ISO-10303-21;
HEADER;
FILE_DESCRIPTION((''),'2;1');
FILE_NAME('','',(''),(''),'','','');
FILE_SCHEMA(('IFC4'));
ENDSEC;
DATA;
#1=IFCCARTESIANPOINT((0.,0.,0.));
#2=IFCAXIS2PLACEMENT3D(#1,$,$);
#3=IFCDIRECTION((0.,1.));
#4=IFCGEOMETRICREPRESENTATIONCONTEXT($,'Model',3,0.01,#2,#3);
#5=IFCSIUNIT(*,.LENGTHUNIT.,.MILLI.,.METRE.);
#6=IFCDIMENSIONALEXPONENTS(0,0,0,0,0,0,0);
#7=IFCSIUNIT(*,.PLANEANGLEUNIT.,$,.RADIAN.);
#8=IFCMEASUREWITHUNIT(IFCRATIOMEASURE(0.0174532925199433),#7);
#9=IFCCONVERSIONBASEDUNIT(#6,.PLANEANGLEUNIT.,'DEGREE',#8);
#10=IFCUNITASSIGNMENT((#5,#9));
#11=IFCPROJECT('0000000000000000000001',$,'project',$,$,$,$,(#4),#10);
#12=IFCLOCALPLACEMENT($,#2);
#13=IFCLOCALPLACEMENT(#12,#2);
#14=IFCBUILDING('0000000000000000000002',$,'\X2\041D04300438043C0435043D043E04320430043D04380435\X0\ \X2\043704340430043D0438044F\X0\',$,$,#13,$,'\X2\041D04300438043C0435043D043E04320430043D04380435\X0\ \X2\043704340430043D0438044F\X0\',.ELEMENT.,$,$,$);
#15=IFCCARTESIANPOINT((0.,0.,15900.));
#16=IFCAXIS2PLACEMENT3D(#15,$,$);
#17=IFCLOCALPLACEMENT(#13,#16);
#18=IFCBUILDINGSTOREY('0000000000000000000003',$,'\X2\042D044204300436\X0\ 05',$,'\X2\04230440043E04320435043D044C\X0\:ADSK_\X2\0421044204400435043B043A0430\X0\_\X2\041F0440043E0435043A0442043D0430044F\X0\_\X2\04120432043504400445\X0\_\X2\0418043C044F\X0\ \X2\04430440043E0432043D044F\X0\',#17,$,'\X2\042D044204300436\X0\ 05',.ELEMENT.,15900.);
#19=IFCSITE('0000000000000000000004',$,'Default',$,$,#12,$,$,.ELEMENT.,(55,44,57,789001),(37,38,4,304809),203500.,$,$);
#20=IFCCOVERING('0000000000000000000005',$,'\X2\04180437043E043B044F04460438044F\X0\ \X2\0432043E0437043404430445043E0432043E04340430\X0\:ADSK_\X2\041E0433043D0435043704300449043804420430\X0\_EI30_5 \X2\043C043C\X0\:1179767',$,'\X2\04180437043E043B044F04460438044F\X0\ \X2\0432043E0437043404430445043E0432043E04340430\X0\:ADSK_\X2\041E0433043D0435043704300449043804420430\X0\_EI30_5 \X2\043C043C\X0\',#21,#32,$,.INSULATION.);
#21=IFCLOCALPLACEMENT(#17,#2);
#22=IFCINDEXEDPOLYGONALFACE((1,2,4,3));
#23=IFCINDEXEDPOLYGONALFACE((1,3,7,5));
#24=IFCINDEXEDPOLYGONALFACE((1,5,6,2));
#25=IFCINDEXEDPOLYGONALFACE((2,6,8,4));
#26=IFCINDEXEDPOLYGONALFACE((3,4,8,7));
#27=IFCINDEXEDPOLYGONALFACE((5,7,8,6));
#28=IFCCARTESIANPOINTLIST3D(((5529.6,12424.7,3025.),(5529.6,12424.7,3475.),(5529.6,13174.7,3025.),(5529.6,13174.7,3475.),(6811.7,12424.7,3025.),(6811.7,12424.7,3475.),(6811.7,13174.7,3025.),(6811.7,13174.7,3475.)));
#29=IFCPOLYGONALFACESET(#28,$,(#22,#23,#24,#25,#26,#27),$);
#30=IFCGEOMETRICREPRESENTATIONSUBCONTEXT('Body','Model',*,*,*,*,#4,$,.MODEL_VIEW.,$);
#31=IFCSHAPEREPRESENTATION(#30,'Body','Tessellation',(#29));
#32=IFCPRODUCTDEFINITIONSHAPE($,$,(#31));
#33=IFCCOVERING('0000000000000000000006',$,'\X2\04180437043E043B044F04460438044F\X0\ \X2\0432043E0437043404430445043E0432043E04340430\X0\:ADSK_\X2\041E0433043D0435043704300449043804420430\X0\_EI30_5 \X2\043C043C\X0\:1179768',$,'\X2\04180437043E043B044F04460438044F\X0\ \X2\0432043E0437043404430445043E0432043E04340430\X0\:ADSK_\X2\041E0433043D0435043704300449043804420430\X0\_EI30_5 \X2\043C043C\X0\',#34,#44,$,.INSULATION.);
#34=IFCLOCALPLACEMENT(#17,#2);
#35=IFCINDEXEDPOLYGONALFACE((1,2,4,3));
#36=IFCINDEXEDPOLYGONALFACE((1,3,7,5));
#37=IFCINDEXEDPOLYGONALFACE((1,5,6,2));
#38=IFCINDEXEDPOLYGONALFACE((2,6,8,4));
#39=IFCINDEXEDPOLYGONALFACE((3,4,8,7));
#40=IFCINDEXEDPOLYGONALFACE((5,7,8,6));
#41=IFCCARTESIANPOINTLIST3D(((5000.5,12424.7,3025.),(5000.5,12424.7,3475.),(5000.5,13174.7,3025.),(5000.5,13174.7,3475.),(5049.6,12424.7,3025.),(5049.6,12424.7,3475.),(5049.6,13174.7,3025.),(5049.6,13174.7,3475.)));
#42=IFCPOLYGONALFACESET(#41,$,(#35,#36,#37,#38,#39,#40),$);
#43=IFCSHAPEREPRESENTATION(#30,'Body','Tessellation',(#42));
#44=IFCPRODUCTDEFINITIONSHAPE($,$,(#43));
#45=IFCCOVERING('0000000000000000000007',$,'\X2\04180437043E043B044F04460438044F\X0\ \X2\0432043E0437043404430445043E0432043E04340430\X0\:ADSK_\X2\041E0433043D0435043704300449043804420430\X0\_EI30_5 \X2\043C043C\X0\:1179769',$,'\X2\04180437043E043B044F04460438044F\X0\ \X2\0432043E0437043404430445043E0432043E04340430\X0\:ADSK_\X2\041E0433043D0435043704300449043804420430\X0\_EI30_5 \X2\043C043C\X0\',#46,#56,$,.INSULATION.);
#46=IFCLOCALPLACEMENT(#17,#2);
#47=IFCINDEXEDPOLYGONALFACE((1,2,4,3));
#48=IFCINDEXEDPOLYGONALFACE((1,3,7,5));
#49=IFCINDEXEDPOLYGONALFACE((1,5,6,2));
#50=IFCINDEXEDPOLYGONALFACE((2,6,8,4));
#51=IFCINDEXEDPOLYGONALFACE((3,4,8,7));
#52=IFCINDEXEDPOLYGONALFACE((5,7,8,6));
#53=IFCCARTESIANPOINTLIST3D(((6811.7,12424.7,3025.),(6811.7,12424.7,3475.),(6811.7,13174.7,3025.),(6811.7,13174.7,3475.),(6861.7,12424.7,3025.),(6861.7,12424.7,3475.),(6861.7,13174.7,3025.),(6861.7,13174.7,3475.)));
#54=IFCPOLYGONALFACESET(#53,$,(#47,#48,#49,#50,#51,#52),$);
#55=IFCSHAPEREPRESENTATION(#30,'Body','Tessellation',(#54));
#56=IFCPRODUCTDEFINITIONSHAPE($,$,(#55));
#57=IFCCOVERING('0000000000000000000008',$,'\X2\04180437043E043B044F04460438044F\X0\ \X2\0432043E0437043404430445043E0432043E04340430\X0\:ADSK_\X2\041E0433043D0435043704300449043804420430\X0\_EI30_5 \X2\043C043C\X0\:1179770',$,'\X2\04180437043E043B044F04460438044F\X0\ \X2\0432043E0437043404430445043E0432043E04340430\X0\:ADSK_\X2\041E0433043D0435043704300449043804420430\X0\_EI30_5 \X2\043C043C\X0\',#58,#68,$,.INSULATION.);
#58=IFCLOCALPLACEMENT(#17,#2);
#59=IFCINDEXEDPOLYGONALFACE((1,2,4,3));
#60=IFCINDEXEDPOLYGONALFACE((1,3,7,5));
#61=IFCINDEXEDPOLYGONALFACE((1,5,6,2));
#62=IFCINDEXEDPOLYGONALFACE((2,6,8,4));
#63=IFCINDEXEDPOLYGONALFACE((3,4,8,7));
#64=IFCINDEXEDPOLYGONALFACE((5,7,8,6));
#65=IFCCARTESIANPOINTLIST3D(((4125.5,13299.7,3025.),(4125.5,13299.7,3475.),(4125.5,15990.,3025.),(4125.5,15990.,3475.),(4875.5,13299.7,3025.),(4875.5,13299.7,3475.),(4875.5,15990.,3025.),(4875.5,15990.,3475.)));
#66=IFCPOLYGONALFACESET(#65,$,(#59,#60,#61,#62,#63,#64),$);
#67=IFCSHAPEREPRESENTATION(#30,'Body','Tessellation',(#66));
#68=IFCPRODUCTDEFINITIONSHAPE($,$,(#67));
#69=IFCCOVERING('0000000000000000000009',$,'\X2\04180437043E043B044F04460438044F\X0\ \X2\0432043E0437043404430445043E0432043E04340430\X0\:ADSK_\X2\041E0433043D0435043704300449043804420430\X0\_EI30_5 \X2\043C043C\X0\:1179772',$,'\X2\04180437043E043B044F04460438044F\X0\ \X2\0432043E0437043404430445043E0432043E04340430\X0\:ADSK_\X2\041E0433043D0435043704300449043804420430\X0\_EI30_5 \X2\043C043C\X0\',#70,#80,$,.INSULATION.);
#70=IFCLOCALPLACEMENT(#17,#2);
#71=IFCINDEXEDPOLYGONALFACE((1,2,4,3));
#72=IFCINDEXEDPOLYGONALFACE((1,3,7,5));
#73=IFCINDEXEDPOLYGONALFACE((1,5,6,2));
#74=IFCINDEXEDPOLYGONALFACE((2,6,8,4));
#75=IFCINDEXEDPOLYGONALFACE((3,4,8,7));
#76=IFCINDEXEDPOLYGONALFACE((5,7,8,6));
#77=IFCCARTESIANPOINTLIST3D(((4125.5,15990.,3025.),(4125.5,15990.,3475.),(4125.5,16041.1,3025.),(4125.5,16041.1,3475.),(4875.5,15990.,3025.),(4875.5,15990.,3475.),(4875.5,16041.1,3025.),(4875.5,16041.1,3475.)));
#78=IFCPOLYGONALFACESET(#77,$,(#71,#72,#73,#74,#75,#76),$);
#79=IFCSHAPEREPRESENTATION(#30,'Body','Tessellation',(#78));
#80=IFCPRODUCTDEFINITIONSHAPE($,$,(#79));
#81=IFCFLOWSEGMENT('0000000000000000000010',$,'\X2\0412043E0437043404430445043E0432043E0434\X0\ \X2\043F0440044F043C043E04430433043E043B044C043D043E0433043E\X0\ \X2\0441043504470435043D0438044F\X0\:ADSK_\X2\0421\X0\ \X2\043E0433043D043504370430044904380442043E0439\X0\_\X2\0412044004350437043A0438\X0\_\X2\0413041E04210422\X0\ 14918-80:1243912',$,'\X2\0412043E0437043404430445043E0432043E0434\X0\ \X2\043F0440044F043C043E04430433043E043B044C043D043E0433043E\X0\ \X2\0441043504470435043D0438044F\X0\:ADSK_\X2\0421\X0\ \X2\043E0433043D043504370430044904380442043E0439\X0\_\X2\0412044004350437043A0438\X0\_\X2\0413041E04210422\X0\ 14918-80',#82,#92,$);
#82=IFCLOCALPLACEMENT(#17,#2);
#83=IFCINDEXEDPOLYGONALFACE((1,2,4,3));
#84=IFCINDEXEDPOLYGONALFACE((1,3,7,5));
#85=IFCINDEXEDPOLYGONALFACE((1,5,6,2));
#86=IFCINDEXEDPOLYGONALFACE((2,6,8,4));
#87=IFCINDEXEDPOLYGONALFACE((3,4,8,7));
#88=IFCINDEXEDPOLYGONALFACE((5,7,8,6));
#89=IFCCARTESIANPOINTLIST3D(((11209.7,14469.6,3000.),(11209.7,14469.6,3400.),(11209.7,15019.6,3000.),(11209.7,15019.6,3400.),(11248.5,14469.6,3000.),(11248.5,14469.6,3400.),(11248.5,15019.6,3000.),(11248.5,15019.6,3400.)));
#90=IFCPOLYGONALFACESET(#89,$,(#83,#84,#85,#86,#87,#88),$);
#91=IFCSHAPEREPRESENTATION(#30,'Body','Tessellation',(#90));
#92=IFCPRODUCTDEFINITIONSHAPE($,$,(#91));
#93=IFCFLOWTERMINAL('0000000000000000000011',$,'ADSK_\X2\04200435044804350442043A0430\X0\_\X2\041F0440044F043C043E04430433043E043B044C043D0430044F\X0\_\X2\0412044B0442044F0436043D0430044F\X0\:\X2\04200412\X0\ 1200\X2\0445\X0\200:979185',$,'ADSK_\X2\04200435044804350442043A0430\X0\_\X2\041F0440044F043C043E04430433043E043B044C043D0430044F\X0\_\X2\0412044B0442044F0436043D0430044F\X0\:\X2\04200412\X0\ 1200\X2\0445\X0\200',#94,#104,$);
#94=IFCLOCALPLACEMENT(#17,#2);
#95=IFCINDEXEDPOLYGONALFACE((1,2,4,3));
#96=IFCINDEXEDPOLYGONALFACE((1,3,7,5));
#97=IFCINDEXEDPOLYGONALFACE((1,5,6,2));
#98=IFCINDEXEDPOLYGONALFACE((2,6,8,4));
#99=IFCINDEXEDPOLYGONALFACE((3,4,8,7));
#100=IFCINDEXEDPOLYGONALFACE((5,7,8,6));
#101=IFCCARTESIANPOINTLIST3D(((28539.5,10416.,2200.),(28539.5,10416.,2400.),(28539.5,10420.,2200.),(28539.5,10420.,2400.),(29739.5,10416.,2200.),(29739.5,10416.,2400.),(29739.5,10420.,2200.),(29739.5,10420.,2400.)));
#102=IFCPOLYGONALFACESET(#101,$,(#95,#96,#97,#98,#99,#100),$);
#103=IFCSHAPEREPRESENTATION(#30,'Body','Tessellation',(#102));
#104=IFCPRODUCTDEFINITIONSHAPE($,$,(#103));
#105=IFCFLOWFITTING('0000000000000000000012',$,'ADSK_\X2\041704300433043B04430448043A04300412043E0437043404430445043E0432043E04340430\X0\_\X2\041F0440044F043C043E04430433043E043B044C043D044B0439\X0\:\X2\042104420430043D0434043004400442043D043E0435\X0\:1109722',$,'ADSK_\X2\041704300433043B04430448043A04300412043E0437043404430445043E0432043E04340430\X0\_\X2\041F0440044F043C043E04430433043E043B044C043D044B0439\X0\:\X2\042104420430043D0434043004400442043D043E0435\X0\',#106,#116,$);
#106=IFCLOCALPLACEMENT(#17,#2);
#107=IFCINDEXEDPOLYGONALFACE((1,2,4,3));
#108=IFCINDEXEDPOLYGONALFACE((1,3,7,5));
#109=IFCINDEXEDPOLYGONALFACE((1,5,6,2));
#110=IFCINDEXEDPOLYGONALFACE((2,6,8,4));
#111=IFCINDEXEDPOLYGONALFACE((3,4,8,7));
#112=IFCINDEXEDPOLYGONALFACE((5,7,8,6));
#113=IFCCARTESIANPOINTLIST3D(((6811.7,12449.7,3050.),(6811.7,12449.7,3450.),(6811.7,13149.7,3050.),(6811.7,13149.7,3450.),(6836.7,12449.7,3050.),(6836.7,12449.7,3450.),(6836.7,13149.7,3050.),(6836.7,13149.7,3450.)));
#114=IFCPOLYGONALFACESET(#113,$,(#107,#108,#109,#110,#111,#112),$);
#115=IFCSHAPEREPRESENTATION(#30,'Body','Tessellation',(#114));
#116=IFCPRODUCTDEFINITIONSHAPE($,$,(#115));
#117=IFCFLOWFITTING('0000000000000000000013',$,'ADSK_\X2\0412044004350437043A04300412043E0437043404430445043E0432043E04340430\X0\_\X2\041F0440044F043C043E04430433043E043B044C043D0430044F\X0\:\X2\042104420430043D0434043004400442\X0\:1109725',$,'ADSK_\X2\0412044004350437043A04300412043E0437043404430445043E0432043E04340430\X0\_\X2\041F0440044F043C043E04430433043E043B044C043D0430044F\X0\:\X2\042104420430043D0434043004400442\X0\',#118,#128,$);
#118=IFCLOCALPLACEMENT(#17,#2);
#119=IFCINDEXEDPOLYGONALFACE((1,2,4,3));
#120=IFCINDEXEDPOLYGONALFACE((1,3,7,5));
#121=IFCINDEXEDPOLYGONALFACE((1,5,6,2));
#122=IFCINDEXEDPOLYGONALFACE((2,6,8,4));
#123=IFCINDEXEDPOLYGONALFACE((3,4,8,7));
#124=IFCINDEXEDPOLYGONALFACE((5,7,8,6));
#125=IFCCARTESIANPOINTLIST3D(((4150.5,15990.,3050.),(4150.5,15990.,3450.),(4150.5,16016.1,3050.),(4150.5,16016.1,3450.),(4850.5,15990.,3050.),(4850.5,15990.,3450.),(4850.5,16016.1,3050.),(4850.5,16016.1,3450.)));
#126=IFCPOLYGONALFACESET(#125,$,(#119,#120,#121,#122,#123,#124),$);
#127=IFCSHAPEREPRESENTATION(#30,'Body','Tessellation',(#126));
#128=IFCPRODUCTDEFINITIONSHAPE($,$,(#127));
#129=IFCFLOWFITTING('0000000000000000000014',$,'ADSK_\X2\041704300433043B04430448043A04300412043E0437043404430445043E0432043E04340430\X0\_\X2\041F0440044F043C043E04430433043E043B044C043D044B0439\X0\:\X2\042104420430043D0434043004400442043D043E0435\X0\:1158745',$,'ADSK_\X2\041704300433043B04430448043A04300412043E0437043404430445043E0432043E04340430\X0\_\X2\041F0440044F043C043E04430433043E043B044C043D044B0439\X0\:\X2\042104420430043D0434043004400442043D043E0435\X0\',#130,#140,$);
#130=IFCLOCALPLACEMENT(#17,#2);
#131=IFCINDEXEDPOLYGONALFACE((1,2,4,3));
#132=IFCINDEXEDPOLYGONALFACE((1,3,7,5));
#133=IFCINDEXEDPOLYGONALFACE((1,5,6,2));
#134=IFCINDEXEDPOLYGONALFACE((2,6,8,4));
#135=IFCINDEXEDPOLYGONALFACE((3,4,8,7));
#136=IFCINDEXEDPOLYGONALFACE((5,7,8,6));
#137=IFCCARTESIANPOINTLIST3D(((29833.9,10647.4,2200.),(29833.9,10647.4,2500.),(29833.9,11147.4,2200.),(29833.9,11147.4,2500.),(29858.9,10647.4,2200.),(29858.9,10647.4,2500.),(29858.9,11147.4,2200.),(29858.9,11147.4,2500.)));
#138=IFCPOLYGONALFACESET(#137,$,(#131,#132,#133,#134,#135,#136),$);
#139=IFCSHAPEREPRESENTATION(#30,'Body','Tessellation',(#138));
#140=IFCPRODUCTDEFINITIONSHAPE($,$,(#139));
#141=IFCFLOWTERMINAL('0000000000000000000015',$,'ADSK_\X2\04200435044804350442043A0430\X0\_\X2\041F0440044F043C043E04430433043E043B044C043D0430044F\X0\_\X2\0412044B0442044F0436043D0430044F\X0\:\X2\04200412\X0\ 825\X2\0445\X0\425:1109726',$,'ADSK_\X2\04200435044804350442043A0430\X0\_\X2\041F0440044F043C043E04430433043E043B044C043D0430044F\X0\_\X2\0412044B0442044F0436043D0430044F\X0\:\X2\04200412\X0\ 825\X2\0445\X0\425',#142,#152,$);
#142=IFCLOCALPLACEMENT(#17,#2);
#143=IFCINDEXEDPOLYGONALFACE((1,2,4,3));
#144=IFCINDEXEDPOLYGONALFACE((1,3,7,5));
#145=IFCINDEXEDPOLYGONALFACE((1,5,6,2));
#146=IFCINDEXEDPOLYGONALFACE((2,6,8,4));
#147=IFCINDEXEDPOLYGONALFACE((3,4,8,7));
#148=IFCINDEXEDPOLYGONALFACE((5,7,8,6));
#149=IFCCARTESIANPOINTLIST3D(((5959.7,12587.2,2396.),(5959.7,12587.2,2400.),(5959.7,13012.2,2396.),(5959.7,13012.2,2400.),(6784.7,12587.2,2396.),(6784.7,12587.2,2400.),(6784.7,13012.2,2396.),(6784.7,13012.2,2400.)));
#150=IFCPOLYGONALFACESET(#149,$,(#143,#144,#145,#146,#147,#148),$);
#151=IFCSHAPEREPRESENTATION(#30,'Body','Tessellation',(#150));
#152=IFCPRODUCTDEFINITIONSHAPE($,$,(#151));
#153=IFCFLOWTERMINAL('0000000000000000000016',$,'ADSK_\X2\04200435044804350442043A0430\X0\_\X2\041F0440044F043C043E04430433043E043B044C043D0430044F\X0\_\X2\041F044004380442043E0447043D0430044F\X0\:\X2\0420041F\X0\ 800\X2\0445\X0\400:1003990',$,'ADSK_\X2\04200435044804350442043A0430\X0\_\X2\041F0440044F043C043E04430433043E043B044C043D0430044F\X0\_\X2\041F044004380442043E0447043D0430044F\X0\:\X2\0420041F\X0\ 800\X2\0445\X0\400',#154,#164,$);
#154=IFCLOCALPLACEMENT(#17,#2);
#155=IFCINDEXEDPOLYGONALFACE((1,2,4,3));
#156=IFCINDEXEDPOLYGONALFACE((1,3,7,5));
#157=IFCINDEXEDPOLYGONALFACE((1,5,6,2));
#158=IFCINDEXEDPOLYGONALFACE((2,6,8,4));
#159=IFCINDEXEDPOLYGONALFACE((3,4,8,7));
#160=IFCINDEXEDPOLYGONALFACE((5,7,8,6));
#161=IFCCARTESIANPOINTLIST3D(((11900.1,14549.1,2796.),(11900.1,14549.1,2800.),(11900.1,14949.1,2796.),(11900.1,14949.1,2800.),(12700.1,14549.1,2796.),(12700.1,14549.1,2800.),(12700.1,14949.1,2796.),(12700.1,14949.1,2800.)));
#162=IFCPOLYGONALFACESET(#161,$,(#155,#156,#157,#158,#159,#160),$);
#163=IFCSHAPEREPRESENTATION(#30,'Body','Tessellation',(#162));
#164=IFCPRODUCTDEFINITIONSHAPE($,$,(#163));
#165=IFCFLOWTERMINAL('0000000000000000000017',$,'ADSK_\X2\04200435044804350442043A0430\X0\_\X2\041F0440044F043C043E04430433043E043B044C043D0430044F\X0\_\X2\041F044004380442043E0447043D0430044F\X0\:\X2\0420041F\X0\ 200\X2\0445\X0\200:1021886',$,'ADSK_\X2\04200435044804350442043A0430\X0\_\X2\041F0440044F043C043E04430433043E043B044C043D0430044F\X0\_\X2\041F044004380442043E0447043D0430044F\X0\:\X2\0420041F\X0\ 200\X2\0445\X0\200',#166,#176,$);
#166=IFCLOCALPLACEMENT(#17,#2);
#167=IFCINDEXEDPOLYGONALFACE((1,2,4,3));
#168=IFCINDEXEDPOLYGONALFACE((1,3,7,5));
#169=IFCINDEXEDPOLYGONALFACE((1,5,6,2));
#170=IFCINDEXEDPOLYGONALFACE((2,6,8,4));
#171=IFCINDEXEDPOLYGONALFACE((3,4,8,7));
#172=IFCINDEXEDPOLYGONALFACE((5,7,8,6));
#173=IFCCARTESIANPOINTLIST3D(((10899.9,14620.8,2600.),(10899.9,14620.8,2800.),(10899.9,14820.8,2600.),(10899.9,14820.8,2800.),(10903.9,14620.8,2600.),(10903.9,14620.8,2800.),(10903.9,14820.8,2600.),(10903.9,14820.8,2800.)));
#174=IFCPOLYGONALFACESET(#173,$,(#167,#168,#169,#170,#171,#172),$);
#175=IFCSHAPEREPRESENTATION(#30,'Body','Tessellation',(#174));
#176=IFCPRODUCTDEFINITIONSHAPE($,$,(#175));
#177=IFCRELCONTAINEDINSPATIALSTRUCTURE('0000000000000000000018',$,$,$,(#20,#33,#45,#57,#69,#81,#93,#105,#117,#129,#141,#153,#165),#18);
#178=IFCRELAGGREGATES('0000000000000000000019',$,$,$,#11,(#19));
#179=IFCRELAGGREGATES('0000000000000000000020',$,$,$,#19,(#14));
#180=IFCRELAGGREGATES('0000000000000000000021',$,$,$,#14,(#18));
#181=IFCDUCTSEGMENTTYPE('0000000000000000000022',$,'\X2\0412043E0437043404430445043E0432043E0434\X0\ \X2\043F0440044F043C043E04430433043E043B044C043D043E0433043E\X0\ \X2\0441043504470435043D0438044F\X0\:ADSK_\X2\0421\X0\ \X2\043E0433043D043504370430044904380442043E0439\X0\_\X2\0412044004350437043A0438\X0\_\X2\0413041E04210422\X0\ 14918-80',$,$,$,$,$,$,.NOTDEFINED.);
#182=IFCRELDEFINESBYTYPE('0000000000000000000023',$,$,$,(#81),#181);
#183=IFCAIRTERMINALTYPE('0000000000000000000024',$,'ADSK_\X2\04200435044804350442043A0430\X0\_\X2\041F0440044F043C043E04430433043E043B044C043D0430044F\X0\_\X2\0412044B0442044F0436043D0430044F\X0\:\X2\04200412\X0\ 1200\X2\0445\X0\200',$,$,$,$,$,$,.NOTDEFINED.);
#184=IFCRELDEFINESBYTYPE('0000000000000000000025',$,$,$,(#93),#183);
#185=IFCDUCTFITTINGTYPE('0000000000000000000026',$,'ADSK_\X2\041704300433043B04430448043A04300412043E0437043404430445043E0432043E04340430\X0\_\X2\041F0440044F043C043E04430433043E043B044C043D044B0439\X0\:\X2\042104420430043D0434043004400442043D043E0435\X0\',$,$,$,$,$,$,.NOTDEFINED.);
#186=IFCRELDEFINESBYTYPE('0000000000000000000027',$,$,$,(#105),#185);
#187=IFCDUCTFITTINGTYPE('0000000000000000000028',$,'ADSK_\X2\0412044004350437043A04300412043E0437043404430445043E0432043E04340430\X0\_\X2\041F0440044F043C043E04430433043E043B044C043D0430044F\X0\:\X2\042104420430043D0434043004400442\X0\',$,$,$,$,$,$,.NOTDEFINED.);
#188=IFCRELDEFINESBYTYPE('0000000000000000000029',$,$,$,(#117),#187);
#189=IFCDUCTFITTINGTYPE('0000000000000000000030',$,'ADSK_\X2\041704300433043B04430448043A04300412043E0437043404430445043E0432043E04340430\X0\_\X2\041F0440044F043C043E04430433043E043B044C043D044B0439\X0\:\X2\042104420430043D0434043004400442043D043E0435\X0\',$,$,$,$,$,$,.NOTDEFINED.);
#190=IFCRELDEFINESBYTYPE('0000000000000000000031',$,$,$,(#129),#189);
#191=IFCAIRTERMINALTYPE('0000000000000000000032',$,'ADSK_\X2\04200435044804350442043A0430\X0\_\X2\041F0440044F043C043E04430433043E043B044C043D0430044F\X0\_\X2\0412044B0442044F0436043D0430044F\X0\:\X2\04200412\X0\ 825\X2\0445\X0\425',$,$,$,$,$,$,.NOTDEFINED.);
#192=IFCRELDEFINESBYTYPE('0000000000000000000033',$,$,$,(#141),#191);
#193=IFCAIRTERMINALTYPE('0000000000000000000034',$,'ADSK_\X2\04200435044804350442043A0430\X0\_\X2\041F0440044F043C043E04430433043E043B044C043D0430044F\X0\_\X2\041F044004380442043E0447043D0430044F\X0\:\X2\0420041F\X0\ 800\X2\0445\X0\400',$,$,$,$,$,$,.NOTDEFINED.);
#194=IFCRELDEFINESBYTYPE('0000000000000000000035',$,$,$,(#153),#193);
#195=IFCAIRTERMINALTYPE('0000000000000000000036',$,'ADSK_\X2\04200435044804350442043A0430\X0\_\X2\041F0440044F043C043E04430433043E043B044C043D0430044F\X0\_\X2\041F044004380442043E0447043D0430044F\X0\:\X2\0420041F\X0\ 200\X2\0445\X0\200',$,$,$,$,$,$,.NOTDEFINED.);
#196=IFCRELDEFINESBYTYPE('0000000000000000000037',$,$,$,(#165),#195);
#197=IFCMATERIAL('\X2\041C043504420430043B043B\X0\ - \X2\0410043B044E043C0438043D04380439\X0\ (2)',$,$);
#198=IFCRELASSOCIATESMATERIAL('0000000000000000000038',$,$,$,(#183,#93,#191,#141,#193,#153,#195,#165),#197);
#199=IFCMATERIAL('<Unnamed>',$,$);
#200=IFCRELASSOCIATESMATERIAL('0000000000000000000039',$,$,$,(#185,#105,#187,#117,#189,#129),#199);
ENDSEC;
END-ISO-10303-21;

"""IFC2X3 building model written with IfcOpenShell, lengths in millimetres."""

from ifc_helpers import new_model, entity, si_unit, converted_unit, direction, frame, frame_2d, origin, origin_2d_with_axis, place, context, subcontext, project, spatial, rectangle, extrude, source, transform, mapped, material, type_object, type_shapes, element, save


model = new_model("IFC2X3")

# Units and contexts
model_context = context("Model", 3, precision=0.01, world=origin(), true_north=direction((0.0, 1.0)))
body_context = subcontext(model_context, "Body", "Model", "MODEL_VIEW")
ifc_project = project(units=[si_unit("LENGTHUNIT", "METRE", prefix="MILLI"), converted_unit("PLANEANGLEUNIT", "DEGREE", entity("IfcRatioMeasure", 0.0174532925199433), si_unit("PLANEANGLEUNIT", "RADIAN"), dimensions=[0, 0, 0, 0, 0, 0, 0])], contexts=[model_context])

# Site, building, storey
site_placement = place(None, frame((0.0, 0.0, 0.0)))
site = spatial("IfcSite", under=ifc_project, at=site_placement, Name="Default", CompositionType="ELEMENT", RefLatitude=(55, 44, 57, 789001), RefLongitude=(37, 38, 4, 304809), RefElevation=203500.0)
building_placement = place(site_placement, origin())
building = spatial("IfcBuilding", under=site, at=building_placement, Name="Наименование здания", LongName="Наименование здания", CompositionType="ELEMENT")
storey_placement = place(building_placement, frame((0.0, 0.0, 15900.0)))
storey = spatial("IfcBuildingStorey", under=building, at=storey_placement, Name="Этаж 05", ObjectType="Уровень:ADSK_Стрелка_Проектная_Вверх_Имя уровня", LongName="Этаж 05", CompositionType="ELEMENT", Elevation=15900.0)

# Coverings
covering_1_placement = place(storey_placement, frame((5529.6, 12424.7, 3025.0)))
element("IfcCovering", 1, at=covering_1_placement, inside=storey, Name="Изоляция воздуховода:ADSK_Огнезащита_EI30_5 мм:1179767", ObjectType="Изоляция воздуховода:ADSK_Огнезащита_EI30_5 мм", PredefinedType="INSULATION", context=body_context, shape_type="SweptSolid", body=[
    extrude(rectangle(XDim=1282.1, YDim=750.0, at=origin_2d_with_axis()), frame((641.0, 375.0, 0.0)), (0.0, 0.0, 1.0), 450.0),
])
covering_2_placement = place(storey_placement, frame((5000.5, 12424.7, 3025.0)))
element("IfcCovering", 2, at=covering_2_placement, inside=storey, Name="Изоляция воздуховода:ADSK_Огнезащита_EI30_5 мм:1179768", ObjectType="Изоляция воздуховода:ADSK_Огнезащита_EI30_5 мм", PredefinedType="INSULATION", context=body_context, shape_type="SweptSolid", body=[
    extrude(rectangle(XDim=49.2, YDim=750.0, at=frame_2d((0.0, 0.0), x_axis=(1.0, 0.0))), frame((24.6, 375.0, 0.0)), (0.0, 0.0, 1.0), 450.0),
])
covering_3_placement = place(storey_placement, frame((6811.7, 12424.7, 3025.0)))
element("IfcCovering", 3, at=covering_3_placement, inside=storey, Name="Изоляция воздуховода:ADSK_Огнезащита_EI30_5 мм:1179769", ObjectType="Изоляция воздуховода:ADSK_Огнезащита_EI30_5 мм", PredefinedType="INSULATION", context=body_context, shape_type="SweptSolid", body=[
    extrude(rectangle(XDim=50.0, YDim=750.0, at=frame_2d((0.0, 0.0), x_axis=(1.0, 0.0))), frame((25.0, 375.0, 0.0), z_axis=(0.0, 0.0, 1.0), x_axis=(-1.0, 0.0, 0.0)), (0.0, 0.0, 1.0), 450.0),
])
covering_4_placement = place(storey_placement, frame((4125.5, 13299.7, 3025.0)))
element("IfcCovering", 4, at=covering_4_placement, inside=storey, Name="Изоляция воздуховода:ADSK_Огнезащита_EI30_5 мм:1179770", ObjectType="Изоляция воздуховода:ADSK_Огнезащита_EI30_5 мм", PredefinedType="INSULATION", context=body_context, shape_type="SweptSolid", body=[
    extrude(rectangle(XDim=2690.3, YDim=750.0, at=frame_2d((0.0, 0.0), x_axis=(1.0, 0.0))), frame((375.0, 1345.2, 0.0), z_axis=(0.0, 0.0, 1.0), x_axis=(0.0, 1.0, 0.0)), (0.0, 0.0, 1.0), 450.0),
])
covering_5_placement = place(storey_placement, frame((4125.5, 15990.0, 3025.0)))
element("IfcCovering", 5, at=covering_5_placement, inside=storey, Name="Изоляция воздуховода:ADSK_Огнезащита_EI30_5 мм:1179772", ObjectType="Изоляция воздуховода:ADSK_Огнезащита_EI30_5 мм", PredefinedType="INSULATION", context=body_context, shape_type="SweptSolid", body=[
    extrude(rectangle(XDim=750.0, YDim=51.1, at=frame_2d((0.0, 0.0), x_axis=(1.0, 0.0))), frame((375.0, 25.5, 0.0)), (0.0, 0.0, 1.0), 450.0),
])

# Flow segment
duct_segment_type = type_object("IfcDuctSegmentType", Name="Воздуховод прямоугольного сечения:ADSK_С огнезащитой_Врезки_ГОСТ 14918-80", PredefinedType="NOTDEFINED")
flow_segment_placement = place(storey_placement, frame((11209.7, 14469.6, 3000.0)))
element("IfcFlowSegment", 6, at=flow_segment_placement, inside=storey, type_object=duct_segment_type, Name="Воздуховод прямоугольного сечения:ADSK_С огнезащитой_Врезки_ГОСТ 14918-80:1243912", ObjectType="Воздуховод прямоугольного сечения:ADSK_С огнезащитой_Врезки_ГОСТ 14918-80", context=body_context, shape_type="SweptSolid", body=[
    extrude(rectangle(XDim=38.8, YDim=550.0, at=frame_2d((0.0, 0.0), x_axis=(1.0, 0.0))), frame((19.4, 275.0, 0.0)), (0.0, 0.0, 1.0), 400.0),
])

# Flow terminal
ifc_material_1 = material(Name="Металл - Алюминий (2)")
air_terminal_type_1 = type_object("IfcAirTerminalType", Name="ADSK_Решетка_Прямоугольная_Вытяжная:РВ 1200х200", PredefinedType="NOTDEFINED", material=ifc_material_1)
shared_shape_1 = source(origin(), body_context, "Body", "SweptSolid", [
    extrude(rectangle(XDim=4.0, YDim=1200.0, at=origin_2d_with_axis()), frame((0.0, -2.0, -100.0), z_axis=(0.0, 0.0, 1.0), x_axis=(0.0, 1.0, 0.0)), (0.0, 0.0, 1.0), 200.0),
])
type_shapes(air_terminal_type_1, [shared_shape_1])
flow_terminal_1_placement = place(storey_placement, frame((29139.5, 10420.0, 2300.0)))
element("IfcFlowTerminal", 7, at=flow_terminal_1_placement, inside=storey, type_object=air_terminal_type_1, material=ifc_material_1, Name="ADSK_Решетка_Прямоугольная_Вытяжная:РВ 1200х200:979185", ObjectType="ADSK_Решетка_Прямоугольная_Вытяжная:РВ 1200х200", context=body_context, shape_type="MappedRepresentation", body=[
    mapped(shared_shape_1, transform((0.0, 0.0, 0.0), scale=1.0)),
])

# Flow fittings
ifc_material_2 = material(Name="<Unnamed>")
duct_fitting_type_1 = type_object("IfcDuctFittingType", Name="ADSK_ЗаглушкаВоздуховода_Прямоугольный:Стандартное", PredefinedType="NOTDEFINED", material=ifc_material_2)
shared_shape_2 = source(origin(), body_context, "Body", "SweptSolid", [
    extrude(rectangle(XDim=25.0, YDim=700.0, at=frame_2d((0.0, 0.0), x_axis=(1.0, 0.0))), frame((12.5, 0.0, -200.0)), (0.0, 0.0, 1.0), 400.0),
])
type_shapes(duct_fitting_type_1, [shared_shape_2])
flow_fitting_1_placement = place(storey_placement, frame((6811.7, 12799.7, 3250.0)))
element("IfcFlowFitting", 8, at=flow_fitting_1_placement, inside=storey, type_object=duct_fitting_type_1, material=ifc_material_2, Name="ADSK_ЗаглушкаВоздуховода_Прямоугольный:Стандартное:1109722", ObjectType="ADSK_ЗаглушкаВоздуховода_Прямоугольный:Стандартное", context=body_context, shape_type="MappedRepresentation", body=[
    mapped(shared_shape_2, transform((0.0, 0.0, 0.0), scale=1.0)),
])
duct_fitting_type_2 = type_object("IfcDuctFittingType", Name="ADSK_ВрезкаВоздуховода_Прямоугольная:Стандарт", PredefinedType="NOTDEFINED", material=ifc_material_2)
shared_shape_3 = source(origin(), body_context, "Body", "SweptSolid", [
    extrude(rectangle(XDim=26.1, YDim=400.0, at=frame_2d((0.0, 0.0), x_axis=(1.0, 0.0))), frame((7.0, 0.0, -350.0)), (0.0, 0.0, 1.0), 700.0),
])
type_shapes(duct_fitting_type_2, [shared_shape_3])
flow_fitting_2_placement = place(storey_placement, frame((4500.5, 16010.0, 3250.0), z_axis=(-1.0, 0.0, 0.0), x_axis=(0.0, -1.0, 0.0)))
element("IfcFlowFitting", 9, at=flow_fitting_2_placement, inside=storey, type_object=duct_fitting_type_2, material=ifc_material_2, Name="ADSK_ВрезкаВоздуховода_Прямоугольная:Стандарт:1109725", ObjectType="ADSK_ВрезкаВоздуховода_Прямоугольная:Стандарт", context=body_context, shape_type="MappedRepresentation", body=[
    mapped(shared_shape_3, transform((0.0, 0.0, 0.0), scale=1.0)),
])
duct_fitting_type_3 = type_object("IfcDuctFittingType", Name="ADSK_ЗаглушкаВоздуховода_Прямоугольный:Стандартное", PredefinedType="NOTDEFINED", material=ifc_material_2)
shared_shape_4 = source(origin(), body_context, "Body", "SweptSolid", [
    extrude(rectangle(XDim=25.0, YDim=500.0, at=frame_2d((0.0, 0.0), x_axis=(1.0, 0.0))), frame((12.5, 0.0, -150.0)), (0.0, 0.0, 1.0), 300.0),
])
type_shapes(duct_fitting_type_3, [shared_shape_4])
flow_fitting_3_placement = place(storey_placement, frame((29833.9, 10897.4, 2350.0)))
element("IfcFlowFitting", 10, at=flow_fitting_3_placement, inside=storey, type_object=duct_fitting_type_3, material=ifc_material_2, Name="ADSK_ЗаглушкаВоздуховода_Прямоугольный:Стандартное:1158745", ObjectType="ADSK_ЗаглушкаВоздуховода_Прямоугольный:Стандартное", context=body_context, shape_type="MappedRepresentation", body=[
    mapped(shared_shape_4, transform((0.0, 0.0, 0.0), scale=1.0)),
])

# Flow terminals
air_terminal_type_2 = type_object("IfcAirTerminalType", Name="ADSK_Решетка_Прямоугольная_Вытяжная:РВ 825х425", PredefinedType="NOTDEFINED", material=ifc_material_1)
shared_shape_5 = source(origin(), body_context, "Body", "SweptSolid", [
    extrude(rectangle(XDim=4.0, YDim=825.0, at=origin_2d_with_axis()), frame((0.0, -2.0, -212.5), z_axis=(0.0, 0.0, 1.0), x_axis=(0.0, 1.0, 0.0)), (0.0, 0.0, 1.0), 425.0),
])
type_shapes(air_terminal_type_2, [shared_shape_5])
flow_terminal_2_placement = place(storey_placement, frame((6372.2, 12799.7, 2400.0), z_axis=(0.0, 1.0, 0.0), x_axis=(-1.0, 0.0, 0.0)))
element("IfcFlowTerminal", 11, at=flow_terminal_2_placement, inside=storey, type_object=air_terminal_type_2, material=ifc_material_1, Name="ADSK_Решетка_Прямоугольная_Вытяжная:РВ 825х425:1109726", ObjectType="ADSK_Решетка_Прямоугольная_Вытяжная:РВ 825х425", context=body_context, shape_type="MappedRepresentation", body=[
    mapped(shared_shape_5, transform((0.0, 0.0, 0.0), scale=1.0)),
])
air_terminal_type_3 = type_object("IfcAirTerminalType", Name="ADSK_Решетка_Прямоугольная_Приточная:РП 800х400", PredefinedType="NOTDEFINED", material=ifc_material_1)
shared_shape_6 = source(origin(), body_context, "Body", "SweptSolid", [
    extrude(rectangle(XDim=4.0, YDim=800.0, at=origin_2d_with_axis()), frame((0.0, -2.0, -200.0), z_axis=(0.0, 0.0, 1.0), x_axis=(0.0, 1.0, 0.0)), (0.0, 0.0, 1.0), 400.0),
])
type_shapes(air_terminal_type_3, [shared_shape_6])
flow_terminal_3_placement = place(storey_placement, frame((12300.1, 14749.1, 2800.0), z_axis=(0.0, 1.0, 0.0), x_axis=(-1.0, 0.0, 0.0)))
element("IfcFlowTerminal", 12, at=flow_terminal_3_placement, inside=storey, type_object=air_terminal_type_3, material=ifc_material_1, Name="ADSK_Решетка_Прямоугольная_Приточная:РП 800х400:1003990", ObjectType="ADSK_Решетка_Прямоугольная_Приточная:РП 800х400", context=body_context, shape_type="MappedRepresentation", body=[
    mapped(shared_shape_6, transform((0.0, 0.0, 0.0), scale=1.0)),
])

# Flow terminal
air_terminal_type_4 = type_object("IfcAirTerminalType", Name="ADSK_Решетка_Прямоугольная_Приточная:РП 200х200", PredefinedType="NOTDEFINED", material=ifc_material_1)
shared_shape_7 = source(origin(), body_context, "Body", "SweptSolid", [
    extrude(rectangle(XDim=4.0, YDim=200.0, at=origin_2d_with_axis()), frame((0.0, -2.0, -100.0), z_axis=(0.0, 0.0, 1.0), x_axis=(0.0, 1.0, 0.0)), (0.0, 0.0, 1.0), 200.0),
])
type_shapes(air_terminal_type_4, [shared_shape_7])
flow_terminal_4_placement = place(storey_placement, frame((10899.9, 14720.8, 2700.0), z_axis=(0.0, 0.0, 1.0), x_axis=(0.0, 1.0, 0.0)))
element("IfcFlowTerminal", 13, at=flow_terminal_4_placement, inside=storey, type_object=air_terminal_type_4, material=ifc_material_1, Name="ADSK_Решетка_Прямоугольная_Приточная:РП 200х200:1021886", ObjectType="ADSK_Решетка_Прямоугольная_Приточная:РП 200х200", context=body_context, shape_type="MappedRepresentation", body=[
    mapped(shared_shape_7, transform((0.0, 0.0, 0.0), scale=1.0)),
])

save(model, "model.ifc")
